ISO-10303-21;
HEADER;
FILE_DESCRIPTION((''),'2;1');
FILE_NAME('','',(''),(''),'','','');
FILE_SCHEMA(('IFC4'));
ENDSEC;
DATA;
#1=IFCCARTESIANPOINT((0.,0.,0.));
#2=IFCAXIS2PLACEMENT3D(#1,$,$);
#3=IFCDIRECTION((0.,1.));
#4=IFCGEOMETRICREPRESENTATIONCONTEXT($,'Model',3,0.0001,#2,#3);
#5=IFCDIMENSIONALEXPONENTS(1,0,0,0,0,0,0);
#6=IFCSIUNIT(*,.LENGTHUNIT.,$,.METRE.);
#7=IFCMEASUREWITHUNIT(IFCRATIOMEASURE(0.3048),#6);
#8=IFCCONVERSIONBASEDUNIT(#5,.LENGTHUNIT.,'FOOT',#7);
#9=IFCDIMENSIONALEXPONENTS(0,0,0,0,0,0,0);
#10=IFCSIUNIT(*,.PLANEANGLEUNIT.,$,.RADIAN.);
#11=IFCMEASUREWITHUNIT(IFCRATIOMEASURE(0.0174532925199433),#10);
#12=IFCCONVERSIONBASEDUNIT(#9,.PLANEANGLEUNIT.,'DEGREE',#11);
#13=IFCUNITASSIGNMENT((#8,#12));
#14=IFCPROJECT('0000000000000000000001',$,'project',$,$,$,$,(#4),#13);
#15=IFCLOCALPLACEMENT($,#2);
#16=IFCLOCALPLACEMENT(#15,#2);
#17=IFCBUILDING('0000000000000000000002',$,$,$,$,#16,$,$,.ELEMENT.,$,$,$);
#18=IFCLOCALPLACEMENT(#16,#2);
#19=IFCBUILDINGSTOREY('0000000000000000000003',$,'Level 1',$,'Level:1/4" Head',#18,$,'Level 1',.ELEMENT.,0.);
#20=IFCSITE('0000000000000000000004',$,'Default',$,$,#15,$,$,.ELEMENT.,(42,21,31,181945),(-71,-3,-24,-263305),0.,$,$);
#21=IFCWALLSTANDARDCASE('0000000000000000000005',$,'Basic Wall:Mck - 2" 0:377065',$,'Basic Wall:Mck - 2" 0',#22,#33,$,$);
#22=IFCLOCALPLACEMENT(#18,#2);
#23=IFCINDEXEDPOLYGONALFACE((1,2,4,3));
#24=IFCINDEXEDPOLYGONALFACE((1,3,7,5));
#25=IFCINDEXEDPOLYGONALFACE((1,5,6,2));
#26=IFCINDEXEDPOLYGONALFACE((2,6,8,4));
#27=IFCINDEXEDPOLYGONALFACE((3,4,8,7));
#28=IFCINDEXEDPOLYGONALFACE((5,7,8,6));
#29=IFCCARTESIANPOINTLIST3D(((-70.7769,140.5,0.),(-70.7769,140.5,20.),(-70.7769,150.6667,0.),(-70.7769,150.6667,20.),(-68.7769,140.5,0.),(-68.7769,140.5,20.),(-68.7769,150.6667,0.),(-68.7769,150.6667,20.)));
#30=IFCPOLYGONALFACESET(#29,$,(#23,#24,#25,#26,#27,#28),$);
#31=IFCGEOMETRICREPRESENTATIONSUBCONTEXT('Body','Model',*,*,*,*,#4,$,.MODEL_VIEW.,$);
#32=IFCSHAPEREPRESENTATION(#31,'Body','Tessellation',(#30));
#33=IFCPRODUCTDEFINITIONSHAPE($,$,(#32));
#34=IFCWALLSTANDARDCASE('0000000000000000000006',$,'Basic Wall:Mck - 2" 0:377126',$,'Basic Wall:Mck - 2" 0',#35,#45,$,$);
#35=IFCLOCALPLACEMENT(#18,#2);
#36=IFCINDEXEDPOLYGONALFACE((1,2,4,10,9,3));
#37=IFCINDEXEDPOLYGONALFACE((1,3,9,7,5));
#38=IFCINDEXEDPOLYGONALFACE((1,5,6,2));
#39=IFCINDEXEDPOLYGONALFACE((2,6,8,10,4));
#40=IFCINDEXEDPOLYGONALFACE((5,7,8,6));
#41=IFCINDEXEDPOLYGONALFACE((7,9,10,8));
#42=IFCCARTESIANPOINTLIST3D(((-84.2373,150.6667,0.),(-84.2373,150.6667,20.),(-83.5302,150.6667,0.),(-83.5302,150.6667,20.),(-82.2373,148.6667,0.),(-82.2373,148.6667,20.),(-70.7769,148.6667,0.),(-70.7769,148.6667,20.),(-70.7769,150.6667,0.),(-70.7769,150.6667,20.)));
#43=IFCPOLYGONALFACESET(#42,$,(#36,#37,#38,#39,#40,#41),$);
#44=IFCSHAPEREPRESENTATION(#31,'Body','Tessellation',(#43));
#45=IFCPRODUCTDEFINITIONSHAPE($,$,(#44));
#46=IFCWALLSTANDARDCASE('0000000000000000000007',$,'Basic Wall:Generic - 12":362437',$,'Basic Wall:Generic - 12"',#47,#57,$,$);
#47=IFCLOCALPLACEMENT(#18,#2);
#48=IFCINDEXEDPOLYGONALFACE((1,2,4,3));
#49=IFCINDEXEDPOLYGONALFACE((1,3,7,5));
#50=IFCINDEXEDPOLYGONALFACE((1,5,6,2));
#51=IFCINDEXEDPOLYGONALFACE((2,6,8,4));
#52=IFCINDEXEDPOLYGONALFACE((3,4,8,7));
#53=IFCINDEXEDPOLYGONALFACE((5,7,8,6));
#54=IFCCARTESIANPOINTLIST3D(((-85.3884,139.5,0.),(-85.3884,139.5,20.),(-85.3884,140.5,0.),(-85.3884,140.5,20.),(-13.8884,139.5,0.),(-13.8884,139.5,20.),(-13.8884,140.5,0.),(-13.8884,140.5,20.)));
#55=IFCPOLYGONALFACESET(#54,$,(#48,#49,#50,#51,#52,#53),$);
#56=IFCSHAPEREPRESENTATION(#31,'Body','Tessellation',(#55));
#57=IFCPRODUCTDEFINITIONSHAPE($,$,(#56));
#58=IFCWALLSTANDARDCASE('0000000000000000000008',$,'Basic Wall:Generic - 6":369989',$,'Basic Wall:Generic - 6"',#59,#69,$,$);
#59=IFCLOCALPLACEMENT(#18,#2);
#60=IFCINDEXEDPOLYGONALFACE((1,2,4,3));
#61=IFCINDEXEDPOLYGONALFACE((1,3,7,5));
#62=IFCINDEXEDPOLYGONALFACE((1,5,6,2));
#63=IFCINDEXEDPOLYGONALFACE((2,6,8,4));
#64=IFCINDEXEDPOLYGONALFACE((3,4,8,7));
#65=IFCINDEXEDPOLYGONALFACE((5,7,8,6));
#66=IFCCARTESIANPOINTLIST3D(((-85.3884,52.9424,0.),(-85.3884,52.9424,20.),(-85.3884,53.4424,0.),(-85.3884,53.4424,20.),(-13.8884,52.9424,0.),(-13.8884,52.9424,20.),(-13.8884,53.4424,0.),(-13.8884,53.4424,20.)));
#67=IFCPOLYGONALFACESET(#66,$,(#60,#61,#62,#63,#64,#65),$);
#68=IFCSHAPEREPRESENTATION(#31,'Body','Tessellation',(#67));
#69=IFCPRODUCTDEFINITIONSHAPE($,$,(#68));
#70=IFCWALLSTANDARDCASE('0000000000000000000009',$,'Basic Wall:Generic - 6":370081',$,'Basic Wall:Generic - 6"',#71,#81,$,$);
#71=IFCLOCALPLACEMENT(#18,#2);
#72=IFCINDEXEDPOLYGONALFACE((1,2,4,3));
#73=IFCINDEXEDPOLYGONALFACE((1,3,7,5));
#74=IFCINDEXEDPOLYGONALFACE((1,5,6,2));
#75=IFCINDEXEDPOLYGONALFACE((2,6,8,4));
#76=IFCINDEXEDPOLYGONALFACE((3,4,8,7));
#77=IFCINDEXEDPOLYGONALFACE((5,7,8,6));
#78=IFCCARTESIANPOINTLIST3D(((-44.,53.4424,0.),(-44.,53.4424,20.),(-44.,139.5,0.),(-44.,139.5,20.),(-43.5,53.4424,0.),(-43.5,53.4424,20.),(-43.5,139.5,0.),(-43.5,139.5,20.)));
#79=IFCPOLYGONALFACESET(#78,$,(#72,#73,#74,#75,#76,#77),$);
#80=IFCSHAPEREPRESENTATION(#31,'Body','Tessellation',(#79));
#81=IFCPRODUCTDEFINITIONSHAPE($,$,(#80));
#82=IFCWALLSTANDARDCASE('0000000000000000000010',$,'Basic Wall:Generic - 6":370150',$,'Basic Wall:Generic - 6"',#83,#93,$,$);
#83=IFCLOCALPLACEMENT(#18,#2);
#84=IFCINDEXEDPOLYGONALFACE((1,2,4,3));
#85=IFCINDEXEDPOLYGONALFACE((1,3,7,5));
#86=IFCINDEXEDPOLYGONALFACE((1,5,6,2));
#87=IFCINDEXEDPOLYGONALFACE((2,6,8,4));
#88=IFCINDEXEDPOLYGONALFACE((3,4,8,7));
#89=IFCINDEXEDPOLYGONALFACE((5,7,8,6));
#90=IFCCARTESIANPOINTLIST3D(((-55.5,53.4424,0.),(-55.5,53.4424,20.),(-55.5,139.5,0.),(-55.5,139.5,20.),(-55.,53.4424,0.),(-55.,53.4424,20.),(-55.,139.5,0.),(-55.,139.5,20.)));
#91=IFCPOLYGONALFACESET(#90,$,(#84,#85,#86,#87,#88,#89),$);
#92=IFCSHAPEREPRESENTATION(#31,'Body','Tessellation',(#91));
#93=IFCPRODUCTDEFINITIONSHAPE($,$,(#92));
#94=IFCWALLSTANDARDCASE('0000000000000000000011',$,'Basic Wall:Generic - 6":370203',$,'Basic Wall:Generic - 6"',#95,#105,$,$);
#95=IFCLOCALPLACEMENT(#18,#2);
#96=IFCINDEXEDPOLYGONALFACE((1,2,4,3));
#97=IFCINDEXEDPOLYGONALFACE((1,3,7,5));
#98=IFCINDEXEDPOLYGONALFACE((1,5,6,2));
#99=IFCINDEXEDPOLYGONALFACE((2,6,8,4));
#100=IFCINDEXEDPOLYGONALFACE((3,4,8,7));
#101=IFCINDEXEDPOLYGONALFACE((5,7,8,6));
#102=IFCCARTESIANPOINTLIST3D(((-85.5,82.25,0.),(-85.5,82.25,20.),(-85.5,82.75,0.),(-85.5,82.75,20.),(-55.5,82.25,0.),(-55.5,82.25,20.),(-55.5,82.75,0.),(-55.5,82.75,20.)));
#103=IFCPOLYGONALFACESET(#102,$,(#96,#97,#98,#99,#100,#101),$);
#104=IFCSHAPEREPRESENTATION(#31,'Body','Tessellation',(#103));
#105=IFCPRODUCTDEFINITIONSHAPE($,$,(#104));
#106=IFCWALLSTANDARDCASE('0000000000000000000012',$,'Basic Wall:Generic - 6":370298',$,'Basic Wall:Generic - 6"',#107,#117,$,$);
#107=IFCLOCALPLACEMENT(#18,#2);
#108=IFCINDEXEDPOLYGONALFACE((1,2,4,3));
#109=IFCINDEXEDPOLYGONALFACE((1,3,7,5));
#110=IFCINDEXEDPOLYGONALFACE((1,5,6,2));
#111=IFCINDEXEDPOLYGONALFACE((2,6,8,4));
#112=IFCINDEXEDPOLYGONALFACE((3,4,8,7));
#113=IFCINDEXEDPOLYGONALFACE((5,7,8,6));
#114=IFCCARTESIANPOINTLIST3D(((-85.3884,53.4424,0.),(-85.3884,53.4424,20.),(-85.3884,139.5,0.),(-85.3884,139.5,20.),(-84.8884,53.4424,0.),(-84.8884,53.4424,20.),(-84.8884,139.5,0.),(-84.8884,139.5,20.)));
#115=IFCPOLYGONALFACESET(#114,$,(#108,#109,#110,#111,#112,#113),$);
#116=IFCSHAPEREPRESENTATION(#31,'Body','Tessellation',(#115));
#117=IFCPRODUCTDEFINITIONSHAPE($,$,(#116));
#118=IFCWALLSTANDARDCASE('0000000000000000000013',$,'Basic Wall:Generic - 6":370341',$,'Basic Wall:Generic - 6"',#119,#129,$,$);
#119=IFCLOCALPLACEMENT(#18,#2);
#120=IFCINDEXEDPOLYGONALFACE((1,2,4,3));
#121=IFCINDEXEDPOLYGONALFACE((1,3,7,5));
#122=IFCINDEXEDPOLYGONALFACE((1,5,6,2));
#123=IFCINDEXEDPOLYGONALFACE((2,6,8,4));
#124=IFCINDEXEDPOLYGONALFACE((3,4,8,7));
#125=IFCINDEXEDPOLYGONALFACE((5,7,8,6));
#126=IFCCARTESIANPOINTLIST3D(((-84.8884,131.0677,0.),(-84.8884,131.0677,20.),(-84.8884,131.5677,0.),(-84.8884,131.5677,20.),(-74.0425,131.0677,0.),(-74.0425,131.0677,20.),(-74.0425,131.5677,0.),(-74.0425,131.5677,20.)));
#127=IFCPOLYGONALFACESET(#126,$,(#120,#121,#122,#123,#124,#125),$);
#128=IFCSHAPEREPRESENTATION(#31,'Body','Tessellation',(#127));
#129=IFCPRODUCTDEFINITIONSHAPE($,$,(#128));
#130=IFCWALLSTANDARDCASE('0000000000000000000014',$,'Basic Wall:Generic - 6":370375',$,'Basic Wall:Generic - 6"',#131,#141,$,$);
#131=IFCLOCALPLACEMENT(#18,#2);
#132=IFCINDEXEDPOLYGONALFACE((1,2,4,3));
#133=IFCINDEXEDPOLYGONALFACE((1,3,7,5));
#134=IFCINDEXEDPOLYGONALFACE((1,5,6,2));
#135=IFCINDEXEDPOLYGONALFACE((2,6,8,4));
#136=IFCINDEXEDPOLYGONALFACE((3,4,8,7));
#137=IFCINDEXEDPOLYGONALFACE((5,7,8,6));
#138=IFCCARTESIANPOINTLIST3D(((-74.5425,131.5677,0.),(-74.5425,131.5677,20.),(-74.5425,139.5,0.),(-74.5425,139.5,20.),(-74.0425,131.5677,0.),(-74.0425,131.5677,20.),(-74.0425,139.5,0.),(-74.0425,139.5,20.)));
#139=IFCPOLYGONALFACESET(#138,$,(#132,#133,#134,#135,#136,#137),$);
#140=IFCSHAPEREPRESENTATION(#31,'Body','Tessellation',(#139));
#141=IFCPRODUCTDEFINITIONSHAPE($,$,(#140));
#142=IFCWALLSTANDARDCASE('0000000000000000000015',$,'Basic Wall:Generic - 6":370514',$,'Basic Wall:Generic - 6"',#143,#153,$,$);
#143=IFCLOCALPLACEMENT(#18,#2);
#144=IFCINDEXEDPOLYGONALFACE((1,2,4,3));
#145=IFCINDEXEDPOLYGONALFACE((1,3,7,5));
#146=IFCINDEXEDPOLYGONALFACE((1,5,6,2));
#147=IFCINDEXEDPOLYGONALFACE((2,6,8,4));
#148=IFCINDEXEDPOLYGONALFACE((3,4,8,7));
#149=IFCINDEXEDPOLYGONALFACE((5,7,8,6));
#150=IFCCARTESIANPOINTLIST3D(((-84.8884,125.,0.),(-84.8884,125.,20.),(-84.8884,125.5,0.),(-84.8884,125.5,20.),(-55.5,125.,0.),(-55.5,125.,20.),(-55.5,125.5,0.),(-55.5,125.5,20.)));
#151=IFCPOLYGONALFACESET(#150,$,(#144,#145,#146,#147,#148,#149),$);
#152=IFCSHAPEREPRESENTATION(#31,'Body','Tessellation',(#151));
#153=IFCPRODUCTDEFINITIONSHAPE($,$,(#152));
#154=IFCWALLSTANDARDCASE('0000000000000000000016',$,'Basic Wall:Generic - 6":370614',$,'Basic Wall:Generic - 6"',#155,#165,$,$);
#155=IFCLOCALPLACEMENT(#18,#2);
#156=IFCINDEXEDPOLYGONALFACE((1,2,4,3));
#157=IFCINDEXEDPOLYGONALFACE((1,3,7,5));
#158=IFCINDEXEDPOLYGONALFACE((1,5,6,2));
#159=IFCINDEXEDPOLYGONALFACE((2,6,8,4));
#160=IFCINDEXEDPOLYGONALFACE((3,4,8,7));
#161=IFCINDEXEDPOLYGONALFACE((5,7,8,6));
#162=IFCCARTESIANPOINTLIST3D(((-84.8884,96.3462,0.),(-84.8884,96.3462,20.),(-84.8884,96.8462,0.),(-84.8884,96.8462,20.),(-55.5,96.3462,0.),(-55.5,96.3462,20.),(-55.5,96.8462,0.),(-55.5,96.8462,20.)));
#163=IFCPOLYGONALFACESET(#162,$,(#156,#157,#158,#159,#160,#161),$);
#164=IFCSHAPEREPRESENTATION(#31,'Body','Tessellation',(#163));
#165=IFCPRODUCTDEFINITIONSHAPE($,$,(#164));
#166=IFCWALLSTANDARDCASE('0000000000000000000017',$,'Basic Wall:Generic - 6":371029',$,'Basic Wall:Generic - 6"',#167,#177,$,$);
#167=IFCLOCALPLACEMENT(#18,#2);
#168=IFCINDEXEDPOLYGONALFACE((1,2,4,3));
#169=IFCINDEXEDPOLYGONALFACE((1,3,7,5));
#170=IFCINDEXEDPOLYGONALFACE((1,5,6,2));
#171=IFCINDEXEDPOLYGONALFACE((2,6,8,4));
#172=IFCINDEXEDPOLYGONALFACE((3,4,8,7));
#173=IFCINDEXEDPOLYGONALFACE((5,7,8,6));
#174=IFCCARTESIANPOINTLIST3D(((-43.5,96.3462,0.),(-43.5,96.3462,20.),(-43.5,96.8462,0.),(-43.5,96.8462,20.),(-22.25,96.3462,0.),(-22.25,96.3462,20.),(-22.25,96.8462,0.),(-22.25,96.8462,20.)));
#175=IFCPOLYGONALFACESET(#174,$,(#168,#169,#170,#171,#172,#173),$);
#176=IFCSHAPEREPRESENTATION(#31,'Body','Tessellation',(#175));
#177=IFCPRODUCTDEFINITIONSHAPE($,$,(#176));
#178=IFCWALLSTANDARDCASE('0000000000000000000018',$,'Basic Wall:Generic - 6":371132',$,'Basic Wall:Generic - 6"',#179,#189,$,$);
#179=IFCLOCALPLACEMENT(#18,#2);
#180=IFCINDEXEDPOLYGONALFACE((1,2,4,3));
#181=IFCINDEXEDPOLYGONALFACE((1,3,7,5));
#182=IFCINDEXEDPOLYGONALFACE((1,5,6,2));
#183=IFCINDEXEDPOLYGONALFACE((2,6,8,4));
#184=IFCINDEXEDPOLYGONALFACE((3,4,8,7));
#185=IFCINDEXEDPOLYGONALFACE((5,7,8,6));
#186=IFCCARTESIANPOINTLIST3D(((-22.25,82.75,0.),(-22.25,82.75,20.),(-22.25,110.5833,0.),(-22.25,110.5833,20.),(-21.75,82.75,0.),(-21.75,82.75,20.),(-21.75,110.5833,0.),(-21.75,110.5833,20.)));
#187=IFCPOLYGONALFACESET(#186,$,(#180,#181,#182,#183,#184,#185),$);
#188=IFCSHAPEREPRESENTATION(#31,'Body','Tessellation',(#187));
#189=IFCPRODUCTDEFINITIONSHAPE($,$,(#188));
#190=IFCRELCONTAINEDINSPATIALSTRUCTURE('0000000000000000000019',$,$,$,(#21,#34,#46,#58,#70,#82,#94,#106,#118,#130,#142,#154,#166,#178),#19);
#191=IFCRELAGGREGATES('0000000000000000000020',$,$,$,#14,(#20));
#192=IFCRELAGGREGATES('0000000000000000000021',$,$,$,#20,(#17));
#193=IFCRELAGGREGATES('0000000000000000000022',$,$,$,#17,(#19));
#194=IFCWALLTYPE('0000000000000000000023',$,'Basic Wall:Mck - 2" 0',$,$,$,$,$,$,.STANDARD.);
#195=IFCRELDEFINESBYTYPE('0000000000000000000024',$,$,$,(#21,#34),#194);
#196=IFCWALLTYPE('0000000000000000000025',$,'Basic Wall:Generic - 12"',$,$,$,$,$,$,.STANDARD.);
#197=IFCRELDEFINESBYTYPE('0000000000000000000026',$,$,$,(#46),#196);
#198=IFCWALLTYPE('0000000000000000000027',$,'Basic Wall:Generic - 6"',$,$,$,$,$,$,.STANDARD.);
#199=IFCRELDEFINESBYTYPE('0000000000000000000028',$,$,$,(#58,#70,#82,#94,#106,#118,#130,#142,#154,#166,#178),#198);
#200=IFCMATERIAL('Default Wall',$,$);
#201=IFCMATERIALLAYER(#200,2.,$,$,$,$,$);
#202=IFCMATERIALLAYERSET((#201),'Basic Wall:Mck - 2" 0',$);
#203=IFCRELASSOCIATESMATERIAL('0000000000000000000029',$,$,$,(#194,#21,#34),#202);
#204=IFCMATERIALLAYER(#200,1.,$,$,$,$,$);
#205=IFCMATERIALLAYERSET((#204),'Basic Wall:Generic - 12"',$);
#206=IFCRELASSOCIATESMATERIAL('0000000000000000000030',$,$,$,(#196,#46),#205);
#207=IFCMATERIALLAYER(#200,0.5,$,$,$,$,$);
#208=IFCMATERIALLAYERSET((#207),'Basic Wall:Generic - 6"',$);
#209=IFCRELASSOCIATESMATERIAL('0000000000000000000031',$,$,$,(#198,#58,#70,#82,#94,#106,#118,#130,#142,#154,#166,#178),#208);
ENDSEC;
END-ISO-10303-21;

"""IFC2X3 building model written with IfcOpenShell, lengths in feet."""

from ifc_helpers import new_model, entity, si_unit, converted_unit, direction, frame, frame_2d, origin, place, context, subcontext, project, spatial, polyline, rectangle, outline, extrude, material, layer, layer_set, layer_usage, type_object, element, save


model = new_model("IFC2X3")

# Units and contexts
model_context = context("Model", 3, precision=0.0001, world=origin(), true_north=direction((0.0, 1.0)))
body_context = subcontext(model_context, "Body", "Model", "MODEL_VIEW")
ifc_project = project(units=[converted_unit("LENGTHUNIT", "FOOT", entity("IfcRatioMeasure", 0.3048), si_unit("LENGTHUNIT", "METRE"), dimensions=[1, 0, 0, 0, 0, 0, 0]), converted_unit("PLANEANGLEUNIT", "DEGREE", entity("IfcRatioMeasure", 0.0174532925199433), si_unit("PLANEANGLEUNIT", "RADIAN"), dimensions=[0, 0, 0, 0, 0, 0, 0])], contexts=[model_context])

# Site, building, storey
site_placement = place(None, origin())
site = spatial("IfcSite", under=ifc_project, at=site_placement, Name="Default", CompositionType="ELEMENT", RefLatitude=(42, 21, 31, 181945), RefLongitude=(-71, -3, -24, -263305), RefElevation=0.0)
building_placement = place(site_placement, origin())
building = spatial("IfcBuilding", under=site, at=building_placement, CompositionType="ELEMENT")
storey_placement = place(building_placement, origin())
storey = spatial("IfcBuildingStorey", under=building, at=storey_placement, Name="Level 1", ObjectType="Level:1/4\" Head", LongName="Level 1", CompositionType="ELEMENT", Elevation=0.0)

# Walls
ifc_material_1 = material(Name="Default Wall")
ifc_layer_1 = layer(ifc_material_1, 2.0)
ifc_layer_set_1 = layer_set([ifc_layer_1], Name="Basic Wall:Mck - 2\" 0")
ifc_layer_usage_1 = layer_usage(ifc_layer_set_1, "AXIS2", "NEGATIVE", 1.0)
wall_type_1 = type_object("IfcWallType", Name="Basic Wall:Mck - 2\" 0", PredefinedType="STANDARD", material=ifc_layer_set_1)
wall_1_placement = place(storey_placement, frame((-69.7769, 140.5, 0.0), z_axis=(0.0, 0.0, 1.0), x_axis=(0.0, 1.0, 0.0)))
element("IfcWallStandardCase", 1, at=wall_1_placement, inside=storey, type_object=wall_type_1, material=ifc_layer_usage_1, Name="Basic Wall:Mck - 2\" 0:377065", ObjectType="Basic Wall:Mck - 2\" 0", context=body_context, shape_type="SweptSolid", body=[
    extrude(rectangle(XDim=10.1667, YDim=2.0, at=frame_2d((5.0833, 0.0), x_axis=(-1.0, 0.0))), origin(), (0.0, 0.0, 1.0), 20.0),
])
ifc_layer_usage_2 = layer_usage(ifc_layer_set_1, "AXIS2", "NEGATIVE", 1.0)
wall_2_placement = place(storey_placement, frame((-70.7769, 149.6667, 0.0), z_axis=(0.0, 0.0, 1.0), x_axis=(-1.0, 0.0, 0.0)))
element("IfcWallStandardCase", 2, at=wall_2_placement, inside=storey, type_object=wall_type_1, material=ifc_layer_usage_2, Name="Basic Wall:Mck - 2\" 0:377126", ObjectType="Basic Wall:Mck - 2\" 0", context=body_context, shape_type="SweptSolid", body=[
    extrude(outline(polyline([(13.4604, -1.0), (11.4604, 1.0), (0.0, 1.0), (0.0, -1.0), (12.7533, -1.0), (13.4604, -1.0)])), origin(), (0.0, 0.0, 1.0), 20.0),
])
ifc_layer_2 = layer(ifc_material_1, 1.0)
ifc_layer_set_2 = layer_set([ifc_layer_2], Name="Basic Wall:Generic - 12\"")
ifc_layer_usage_3 = layer_usage(ifc_layer_set_2, "AXIS2", "NEGATIVE", 0.5)
wall_type_2 = type_object("IfcWallType", Name="Basic Wall:Generic - 12\"", PredefinedType="STANDARD", material=ifc_layer_set_2)
wall_3_placement = place(storey_placement, frame((-85.3884, 140.0, 0.0)))
element("IfcWallStandardCase", 3, at=wall_3_placement, inside=storey, type_object=wall_type_2, material=ifc_layer_usage_3, Name="Basic Wall:Generic - 12\":362437", ObjectType="Basic Wall:Generic - 12\"", context=body_context, shape_type="SweptSolid", body=[
    extrude(rectangle(XDim=71.5, YDim=1.0, at=frame_2d((35.75, 0.0), x_axis=(-1.0, 0.0))), origin(), (0.0, 0.0, 1.0), 20.0),
])
ifc_layer_3 = layer(ifc_material_1, 0.5)
ifc_layer_set_3 = layer_set([ifc_layer_3], Name="Basic Wall:Generic - 6\"")
ifc_layer_usage_4 = layer_usage(ifc_layer_set_3, "AXIS2", "NEGATIVE", 0.25)
wall_type_3 = type_object("IfcWallType", Name="Basic Wall:Generic - 6\"", PredefinedType="STANDARD", material=ifc_layer_set_3)
wall_4_placement = place(storey_placement, frame((-85.3884, 53.1924, 0.0)))
element("IfcWallStandardCase", 4, at=wall_4_placement, inside=storey, type_object=wall_type_3, material=ifc_layer_usage_4, Name="Basic Wall:Generic - 6\":369989", ObjectType="Basic Wall:Generic - 6\"", context=body_context, shape_type="SweptSolid", body=[
    extrude(rectangle(XDim=71.5, YDim=0.5, at=frame_2d((35.75, 0.0), x_axis=(-1.0, 0.0))), origin(), (0.0, 0.0, 1.0), 20.0),
])
ifc_layer_usage_5 = layer_usage(ifc_layer_set_3, "AXIS2", "NEGATIVE", 0.25)
wall_5_placement = place(storey_placement, frame((-43.75, 53.4424, 0.0), z_axis=(0.0, 0.0, 1.0), x_axis=(0.0, 1.0, 0.0)))
element("IfcWallStandardCase", 5, at=wall_5_placement, inside=storey, type_object=wall_type_3, material=ifc_layer_usage_5, Name="Basic Wall:Generic - 6\":370081", ObjectType="Basic Wall:Generic - 6\"", context=body_context, shape_type="SweptSolid", body=[
    extrude(rectangle(XDim=86.0576, YDim=0.5, at=frame_2d((43.0288, 0.0), x_axis=(-1.0, 0.0))), origin(), (0.0, 0.0, 1.0), 20.0),
])
ifc_layer_usage_6 = layer_usage(ifc_layer_set_3, "AXIS2", "NEGATIVE", 0.25)
wall_6_placement = place(storey_placement, frame((-55.25, 139.5, 0.0), z_axis=(0.0, 0.0, 1.0), x_axis=(0.0, -1.0, 0.0)))
element("IfcWallStandardCase", 6, at=wall_6_placement, inside=storey, type_object=wall_type_3, material=ifc_layer_usage_6, Name="Basic Wall:Generic - 6\":370150", ObjectType="Basic Wall:Generic - 6\"", context=body_context, shape_type="SweptSolid", body=[
    extrude(rectangle(XDim=86.0576, YDim=0.5, at=frame_2d((43.0288, 0.0), x_axis=(-1.0, 0.0))), origin(), (0.0, 0.0, 1.0), 20.0),
])
ifc_layer_usage_7 = layer_usage(ifc_layer_set_3, "AXIS2", "NEGATIVE", 0.25)
wall_7_placement = place(storey_placement, frame((-85.5, 82.5, 0.0)))
element("IfcWallStandardCase", 7, at=wall_7_placement, inside=storey, type_object=wall_type_3, material=ifc_layer_usage_7, Name="Basic Wall:Generic - 6\":370203", ObjectType="Basic Wall:Generic - 6\"", context=body_context, shape_type="SweptSolid", body=[
    extrude(rectangle(XDim=30.0, YDim=0.5, at=frame_2d((15.0, 0.0), x_axis=(-1.0, 0.0))), origin(), (0.0, 0.0, 1.0), 20.0),
])
ifc_layer_usage_8 = layer_usage(ifc_layer_set_3, "AXIS2", "NEGATIVE", 0.25)
wall_8_placement = place(storey_placement, frame((-85.1384, 139.5, 0.0), z_axis=(0.0, 0.0, 1.0), x_axis=(0.0, -1.0, 0.0)))
element("IfcWallStandardCase", 8, at=wall_8_placement, inside=storey, type_object=wall_type_3, material=ifc_layer_usage_8, Name="Basic Wall:Generic - 6\":370298", ObjectType="Basic Wall:Generic - 6\"", context=body_context, shape_type="SweptSolid", body=[
    extrude(rectangle(XDim=86.0576, YDim=0.5, at=frame_2d((43.0288, 0.0), x_axis=(-1.0, 0.0))), origin(), (0.0, 0.0, 1.0), 20.0),
])
ifc_layer_usage_9 = layer_usage(ifc_layer_set_3, "AXIS2", "NEGATIVE", 0.25)
wall_9_placement = place(storey_placement, frame((-84.8884, 131.3177, 0.0)))
element("IfcWallStandardCase", 9, at=wall_9_placement, inside=storey, type_object=wall_type_3, material=ifc_layer_usage_9, Name="Basic Wall:Generic - 6\":370341", ObjectType="Basic Wall:Generic - 6\"", context=body_context, shape_type="SweptSolid", body=[
    extrude(rectangle(XDim=10.8459, YDim=0.5, at=frame_2d((5.423, 0.0), x_axis=(-1.0, 0.0))), origin(), (0.0, 0.0, 1.0), 20.0),
])
ifc_layer_usage_10 = layer_usage(ifc_layer_set_3, "AXIS2", "NEGATIVE", 0.25)
wall_10_placement = place(storey_placement, frame((-74.2925, 131.5677, 0.0), z_axis=(0.0, 0.0, 1.0), x_axis=(0.0, 1.0, 0.0)))
element("IfcWallStandardCase", 10, at=wall_10_placement, inside=storey, type_object=wall_type_3, material=ifc_layer_usage_10, Name="Basic Wall:Generic - 6\":370375", ObjectType="Basic Wall:Generic - 6\"", context=body_context, shape_type="SweptSolid", body=[
    extrude(rectangle(XDim=7.9323, YDim=0.5, at=frame_2d((3.9661, 0.0), x_axis=(-1.0, 0.0))), origin(), (0.0, 0.0, 1.0), 20.0),
])
ifc_layer_usage_11 = layer_usage(ifc_layer_set_3, "AXIS2", "NEGATIVE", 0.25)
wall_11_placement = place(storey_placement, frame((-84.8884, 125.25, 0.0)))
element("IfcWallStandardCase", 11, at=wall_11_placement, inside=storey, type_object=wall_type_3, material=ifc_layer_usage_11, Name="Basic Wall:Generic - 6\":370514", ObjectType="Basic Wall:Generic - 6\"", context=body_context, shape_type="SweptSolid", body=[
    extrude(rectangle(XDim=29.3884, YDim=0.5, at=frame_2d((14.6942, 0.0), x_axis=(-1.0, 0.0))), origin(), (0.0, 0.0, 1.0), 20.0),
])
ifc_layer_usage_12 = layer_usage(ifc_layer_set_3, "AXIS2", "NEGATIVE", 0.25)
wall_12_placement = place(storey_placement, frame((-84.8884, 96.5962, 0.0)))
element("IfcWallStandardCase", 12, at=wall_12_placement, inside=storey, type_object=wall_type_3, material=ifc_layer_usage_12, Name="Basic Wall:Generic - 6\":370614", ObjectType="Basic Wall:Generic - 6\"", context=body_context, shape_type="SweptSolid", body=[
    extrude(rectangle(XDim=29.3884, YDim=0.5, at=frame_2d((14.6942, 0.0), x_axis=(-1.0, 0.0))), origin(), (0.0, 0.0, 1.0), 20.0),
])
ifc_layer_usage_13 = layer_usage(ifc_layer_set_3, "AXIS2", "NEGATIVE", 0.25)
wall_13_placement = place(storey_placement, frame((-22.25, 96.5962, 0.0), z_axis=(0.0, 0.0, 1.0), x_axis=(-1.0, 0.0, 0.0)))
element("IfcWallStandardCase", 13, at=wall_13_placement, inside=storey, type_object=wall_type_3, material=ifc_layer_usage_13, Name="Basic Wall:Generic - 6\":371029", ObjectType="Basic Wall:Generic - 6\"", context=body_context, shape_type="SweptSolid", body=[
    extrude(rectangle(XDim=21.25, YDim=0.5, at=frame_2d((10.625, 0.0), x_axis=(-1.0, 0.0))), origin(), (0.0, 0.0, 1.0), 20.0),
])
ifc_layer_usage_14 = layer_usage(ifc_layer_set_3, "AXIS2", "NEGATIVE", 0.25)
wall_14_placement = place(storey_placement, frame((-22.0, 110.5833, 0.0), z_axis=(0.0, 0.0, 1.0), x_axis=(0.0, -1.0, 0.0)))
element("IfcWallStandardCase", 14, at=wall_14_placement, inside=storey, type_object=wall_type_3, material=ifc_layer_usage_14, Name="Basic Wall:Generic - 6\":371132", ObjectType="Basic Wall:Generic - 6\"", context=body_context, shape_type="SweptSolid", body=[
    extrude(rectangle(XDim=27.8333, YDim=0.5, at=frame_2d((13.9167, 0.0), x_axis=(-1.0, 0.0))), origin(), (0.0, 0.0, 1.0), 20.0),
])

save(model, "model.ifc")
